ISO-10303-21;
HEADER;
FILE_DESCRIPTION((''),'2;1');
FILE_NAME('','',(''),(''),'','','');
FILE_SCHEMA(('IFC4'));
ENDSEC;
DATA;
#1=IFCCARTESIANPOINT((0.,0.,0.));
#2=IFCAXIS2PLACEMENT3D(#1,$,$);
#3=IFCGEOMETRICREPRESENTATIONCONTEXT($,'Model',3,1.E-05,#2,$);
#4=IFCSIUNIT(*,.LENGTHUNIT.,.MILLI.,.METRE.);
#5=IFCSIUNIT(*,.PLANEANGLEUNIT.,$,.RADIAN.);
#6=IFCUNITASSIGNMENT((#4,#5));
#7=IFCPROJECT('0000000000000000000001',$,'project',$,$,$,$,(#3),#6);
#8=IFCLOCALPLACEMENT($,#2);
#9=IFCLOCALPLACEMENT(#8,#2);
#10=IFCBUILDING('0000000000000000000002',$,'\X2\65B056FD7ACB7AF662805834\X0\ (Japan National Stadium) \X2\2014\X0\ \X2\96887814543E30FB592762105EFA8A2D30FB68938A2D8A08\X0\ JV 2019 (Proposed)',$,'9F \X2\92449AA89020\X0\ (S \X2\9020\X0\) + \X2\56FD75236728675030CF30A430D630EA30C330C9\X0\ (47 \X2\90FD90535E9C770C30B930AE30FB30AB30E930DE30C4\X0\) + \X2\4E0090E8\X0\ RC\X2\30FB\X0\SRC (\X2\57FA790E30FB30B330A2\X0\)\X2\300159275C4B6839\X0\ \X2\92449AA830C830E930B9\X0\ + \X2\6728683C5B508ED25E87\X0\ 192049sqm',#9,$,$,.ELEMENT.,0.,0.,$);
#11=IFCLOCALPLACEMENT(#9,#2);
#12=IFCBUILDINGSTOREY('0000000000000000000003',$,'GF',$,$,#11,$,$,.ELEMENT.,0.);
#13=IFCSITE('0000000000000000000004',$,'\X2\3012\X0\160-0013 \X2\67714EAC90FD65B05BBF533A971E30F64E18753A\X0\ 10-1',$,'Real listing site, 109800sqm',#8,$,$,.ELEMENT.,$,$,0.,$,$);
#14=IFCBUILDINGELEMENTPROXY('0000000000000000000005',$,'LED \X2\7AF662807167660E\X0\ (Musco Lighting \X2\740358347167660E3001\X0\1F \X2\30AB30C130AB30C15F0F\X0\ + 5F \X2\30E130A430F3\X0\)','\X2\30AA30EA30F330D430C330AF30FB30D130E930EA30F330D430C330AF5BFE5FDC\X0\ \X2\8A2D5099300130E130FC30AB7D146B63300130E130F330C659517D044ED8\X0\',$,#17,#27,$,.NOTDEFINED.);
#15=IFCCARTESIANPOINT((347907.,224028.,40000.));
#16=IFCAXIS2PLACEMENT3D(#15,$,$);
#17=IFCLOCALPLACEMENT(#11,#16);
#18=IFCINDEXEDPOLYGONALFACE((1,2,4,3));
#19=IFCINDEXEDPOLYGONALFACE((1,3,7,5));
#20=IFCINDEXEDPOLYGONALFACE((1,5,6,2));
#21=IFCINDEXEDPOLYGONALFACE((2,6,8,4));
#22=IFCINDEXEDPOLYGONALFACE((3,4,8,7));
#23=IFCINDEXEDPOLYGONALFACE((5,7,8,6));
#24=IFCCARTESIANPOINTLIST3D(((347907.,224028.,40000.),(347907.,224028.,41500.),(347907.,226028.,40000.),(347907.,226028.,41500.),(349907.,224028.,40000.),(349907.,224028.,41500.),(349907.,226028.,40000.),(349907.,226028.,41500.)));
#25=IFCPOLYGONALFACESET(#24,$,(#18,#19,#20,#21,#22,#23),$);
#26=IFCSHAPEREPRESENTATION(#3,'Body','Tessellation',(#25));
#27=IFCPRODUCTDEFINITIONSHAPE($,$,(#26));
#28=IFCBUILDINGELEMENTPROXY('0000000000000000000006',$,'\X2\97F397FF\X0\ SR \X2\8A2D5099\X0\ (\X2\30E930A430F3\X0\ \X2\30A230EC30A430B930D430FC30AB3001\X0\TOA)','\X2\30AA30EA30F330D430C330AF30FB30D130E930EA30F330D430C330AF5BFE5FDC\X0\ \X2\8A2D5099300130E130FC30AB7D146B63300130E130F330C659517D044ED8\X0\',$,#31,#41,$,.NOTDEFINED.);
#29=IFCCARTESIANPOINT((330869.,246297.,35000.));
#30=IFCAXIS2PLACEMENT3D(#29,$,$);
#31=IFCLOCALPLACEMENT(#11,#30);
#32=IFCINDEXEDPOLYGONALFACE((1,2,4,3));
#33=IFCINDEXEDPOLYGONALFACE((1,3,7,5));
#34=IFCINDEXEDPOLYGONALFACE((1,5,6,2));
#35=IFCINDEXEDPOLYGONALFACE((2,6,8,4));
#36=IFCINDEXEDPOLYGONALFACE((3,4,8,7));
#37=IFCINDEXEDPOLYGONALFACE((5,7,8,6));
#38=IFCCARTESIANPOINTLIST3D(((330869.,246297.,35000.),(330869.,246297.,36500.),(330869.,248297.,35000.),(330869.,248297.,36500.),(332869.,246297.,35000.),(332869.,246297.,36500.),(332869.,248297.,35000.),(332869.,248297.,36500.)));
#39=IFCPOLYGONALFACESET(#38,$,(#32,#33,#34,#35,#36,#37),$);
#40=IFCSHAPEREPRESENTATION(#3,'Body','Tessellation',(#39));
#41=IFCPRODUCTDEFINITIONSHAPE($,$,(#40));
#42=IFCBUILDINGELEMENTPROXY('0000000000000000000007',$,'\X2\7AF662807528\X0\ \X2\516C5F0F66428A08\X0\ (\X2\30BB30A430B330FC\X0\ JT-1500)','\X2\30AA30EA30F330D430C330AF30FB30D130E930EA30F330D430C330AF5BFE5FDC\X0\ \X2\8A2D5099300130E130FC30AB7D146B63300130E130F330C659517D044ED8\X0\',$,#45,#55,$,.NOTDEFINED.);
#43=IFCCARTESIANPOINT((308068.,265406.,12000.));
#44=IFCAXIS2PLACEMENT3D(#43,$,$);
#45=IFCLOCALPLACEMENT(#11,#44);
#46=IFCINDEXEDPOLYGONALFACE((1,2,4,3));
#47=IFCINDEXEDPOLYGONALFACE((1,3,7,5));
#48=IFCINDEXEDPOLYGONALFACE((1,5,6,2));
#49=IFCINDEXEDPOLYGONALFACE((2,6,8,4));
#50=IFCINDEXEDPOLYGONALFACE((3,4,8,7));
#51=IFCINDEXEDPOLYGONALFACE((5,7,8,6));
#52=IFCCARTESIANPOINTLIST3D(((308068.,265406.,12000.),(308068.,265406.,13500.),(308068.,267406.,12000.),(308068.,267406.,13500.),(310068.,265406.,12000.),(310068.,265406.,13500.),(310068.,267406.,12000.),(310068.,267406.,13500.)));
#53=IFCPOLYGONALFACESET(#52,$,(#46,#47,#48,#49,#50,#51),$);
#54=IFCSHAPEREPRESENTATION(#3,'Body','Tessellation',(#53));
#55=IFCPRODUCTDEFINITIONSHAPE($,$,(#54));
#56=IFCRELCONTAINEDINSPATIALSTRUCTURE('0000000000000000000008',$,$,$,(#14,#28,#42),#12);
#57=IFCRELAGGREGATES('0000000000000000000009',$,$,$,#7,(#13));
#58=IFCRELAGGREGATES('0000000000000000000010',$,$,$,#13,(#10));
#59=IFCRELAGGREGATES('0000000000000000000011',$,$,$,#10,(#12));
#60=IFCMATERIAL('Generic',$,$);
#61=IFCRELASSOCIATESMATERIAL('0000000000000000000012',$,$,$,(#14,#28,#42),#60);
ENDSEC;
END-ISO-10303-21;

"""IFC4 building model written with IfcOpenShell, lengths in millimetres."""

from ifc_helpers import new_model, si_unit, frame, frame_2d, origin, place, context, project, spatial, rectangle, extrude, material, element, save


model = new_model("IFC4")

# Units and contexts
model_context = context("Model", 3, precision=1e-05, world=origin())
ifc_project = project(units=[si_unit("LENGTHUNIT", "METRE", prefix="MILLI"), si_unit("PLANEANGLEUNIT", "RADIAN")], contexts=[model_context])

# Site, building, storey
site_placement = place(None, origin())
site = spatial("IfcSite", under=ifc_project, at=site_placement, Name="〒160-0013 東京都新宿区霞ヶ丘町 10-1", ObjectType="Real listing site, 109800sqm", CompositionType="ELEMENT", RefElevation=0.0)
building_placement = place(site_placement, origin())
building = spatial("IfcBuilding", under=site, at=building_placement, Name="新国立競技場 (Japan National Stadium) — 隈研吾・大成建設・梓設計 JV 2019 (Proposed)", ObjectType="9F 鉄骨造 (S 造) + 国産木材ハイブリッド (47 都道府県スギ・カラマツ) + 一部 RC・SRC (基礎・コア)、大屋根 鉄骨トラス + 木格子軒庇 192049sqm", CompositionType="ELEMENT", ElevationOfRefHeight=0.0, ElevationOfTerrain=0.0)
storey_placement = place(building_placement, origin())
storey = spatial("IfcBuildingStorey", under=building, at=storey_placement, Name="GF", CompositionType="ELEMENT", Elevation=0.0)

# Shared definitions
ifc_material_1 = material(Name="Generic")

# Building element proxies
proxy_1_placement = place(storey_placement, frame((347907.0, 224028.0, 40000.0)))
element("IfcBuildingElementProxy", 1, at=proxy_1_placement, inside=storey, material=ifc_material_1, Name="LED 競技照明 (Musco Lighting 球場照明、1F カチカチ式 + 5F メイン)", Description="オリンピック・パラリンピック対応 設備、メーカ純正、メンテ契約付", PredefinedType="NOTDEFINED", context=model_context, shape_type="SweptSolid", body=[
    extrude(rectangle(XDim=2000.0, YDim=2000.0, at=frame_2d((1000.0, 1000.0))), frame((347907.0, 224028.0, 40000.0)), (0.0, 0.0, 1.0), 1500.0),
])
proxy_2_placement = place(storey_placement, frame((330869.0, 246297.0, 35000.0)))
element("IfcBuildingElementProxy", 2, at=proxy_2_placement, inside=storey, material=ifc_material_1, Name="音響 SR 設備 (ライン アレイスピーカ、TOA)", Description="オリンピック・パラリンピック対応 設備、メーカ純正、メンテ契約付", PredefinedType="NOTDEFINED", context=model_context, shape_type="SweptSolid", body=[
    extrude(rectangle(XDim=2000.0, YDim=2000.0, at=frame_2d((1000.0, 1000.0))), frame((330869.0, 246297.0, 35000.0)), (0.0, 0.0, 1.0), 1500.0),
])
proxy_3_placement = place(storey_placement, frame((308068.0, 265406.0, 12000.0)))
element("IfcBuildingElementProxy", 3, at=proxy_3_placement, inside=storey, material=ifc_material_1, Name="競技用 公式時計 (セイコー JT-1500)", Description="オリンピック・パラリンピック対応 設備、メーカ純正、メンテ契約付", PredefinedType="NOTDEFINED", context=model_context, shape_type="SweptSolid", body=[
    extrude(rectangle(XDim=2000.0, YDim=2000.0, at=frame_2d((1000.0, 1000.0))), frame((308068.0, 265406.0, 12000.0)), (0.0, 0.0, 1.0), 1500.0),
])

save(model, "model.ifc")
